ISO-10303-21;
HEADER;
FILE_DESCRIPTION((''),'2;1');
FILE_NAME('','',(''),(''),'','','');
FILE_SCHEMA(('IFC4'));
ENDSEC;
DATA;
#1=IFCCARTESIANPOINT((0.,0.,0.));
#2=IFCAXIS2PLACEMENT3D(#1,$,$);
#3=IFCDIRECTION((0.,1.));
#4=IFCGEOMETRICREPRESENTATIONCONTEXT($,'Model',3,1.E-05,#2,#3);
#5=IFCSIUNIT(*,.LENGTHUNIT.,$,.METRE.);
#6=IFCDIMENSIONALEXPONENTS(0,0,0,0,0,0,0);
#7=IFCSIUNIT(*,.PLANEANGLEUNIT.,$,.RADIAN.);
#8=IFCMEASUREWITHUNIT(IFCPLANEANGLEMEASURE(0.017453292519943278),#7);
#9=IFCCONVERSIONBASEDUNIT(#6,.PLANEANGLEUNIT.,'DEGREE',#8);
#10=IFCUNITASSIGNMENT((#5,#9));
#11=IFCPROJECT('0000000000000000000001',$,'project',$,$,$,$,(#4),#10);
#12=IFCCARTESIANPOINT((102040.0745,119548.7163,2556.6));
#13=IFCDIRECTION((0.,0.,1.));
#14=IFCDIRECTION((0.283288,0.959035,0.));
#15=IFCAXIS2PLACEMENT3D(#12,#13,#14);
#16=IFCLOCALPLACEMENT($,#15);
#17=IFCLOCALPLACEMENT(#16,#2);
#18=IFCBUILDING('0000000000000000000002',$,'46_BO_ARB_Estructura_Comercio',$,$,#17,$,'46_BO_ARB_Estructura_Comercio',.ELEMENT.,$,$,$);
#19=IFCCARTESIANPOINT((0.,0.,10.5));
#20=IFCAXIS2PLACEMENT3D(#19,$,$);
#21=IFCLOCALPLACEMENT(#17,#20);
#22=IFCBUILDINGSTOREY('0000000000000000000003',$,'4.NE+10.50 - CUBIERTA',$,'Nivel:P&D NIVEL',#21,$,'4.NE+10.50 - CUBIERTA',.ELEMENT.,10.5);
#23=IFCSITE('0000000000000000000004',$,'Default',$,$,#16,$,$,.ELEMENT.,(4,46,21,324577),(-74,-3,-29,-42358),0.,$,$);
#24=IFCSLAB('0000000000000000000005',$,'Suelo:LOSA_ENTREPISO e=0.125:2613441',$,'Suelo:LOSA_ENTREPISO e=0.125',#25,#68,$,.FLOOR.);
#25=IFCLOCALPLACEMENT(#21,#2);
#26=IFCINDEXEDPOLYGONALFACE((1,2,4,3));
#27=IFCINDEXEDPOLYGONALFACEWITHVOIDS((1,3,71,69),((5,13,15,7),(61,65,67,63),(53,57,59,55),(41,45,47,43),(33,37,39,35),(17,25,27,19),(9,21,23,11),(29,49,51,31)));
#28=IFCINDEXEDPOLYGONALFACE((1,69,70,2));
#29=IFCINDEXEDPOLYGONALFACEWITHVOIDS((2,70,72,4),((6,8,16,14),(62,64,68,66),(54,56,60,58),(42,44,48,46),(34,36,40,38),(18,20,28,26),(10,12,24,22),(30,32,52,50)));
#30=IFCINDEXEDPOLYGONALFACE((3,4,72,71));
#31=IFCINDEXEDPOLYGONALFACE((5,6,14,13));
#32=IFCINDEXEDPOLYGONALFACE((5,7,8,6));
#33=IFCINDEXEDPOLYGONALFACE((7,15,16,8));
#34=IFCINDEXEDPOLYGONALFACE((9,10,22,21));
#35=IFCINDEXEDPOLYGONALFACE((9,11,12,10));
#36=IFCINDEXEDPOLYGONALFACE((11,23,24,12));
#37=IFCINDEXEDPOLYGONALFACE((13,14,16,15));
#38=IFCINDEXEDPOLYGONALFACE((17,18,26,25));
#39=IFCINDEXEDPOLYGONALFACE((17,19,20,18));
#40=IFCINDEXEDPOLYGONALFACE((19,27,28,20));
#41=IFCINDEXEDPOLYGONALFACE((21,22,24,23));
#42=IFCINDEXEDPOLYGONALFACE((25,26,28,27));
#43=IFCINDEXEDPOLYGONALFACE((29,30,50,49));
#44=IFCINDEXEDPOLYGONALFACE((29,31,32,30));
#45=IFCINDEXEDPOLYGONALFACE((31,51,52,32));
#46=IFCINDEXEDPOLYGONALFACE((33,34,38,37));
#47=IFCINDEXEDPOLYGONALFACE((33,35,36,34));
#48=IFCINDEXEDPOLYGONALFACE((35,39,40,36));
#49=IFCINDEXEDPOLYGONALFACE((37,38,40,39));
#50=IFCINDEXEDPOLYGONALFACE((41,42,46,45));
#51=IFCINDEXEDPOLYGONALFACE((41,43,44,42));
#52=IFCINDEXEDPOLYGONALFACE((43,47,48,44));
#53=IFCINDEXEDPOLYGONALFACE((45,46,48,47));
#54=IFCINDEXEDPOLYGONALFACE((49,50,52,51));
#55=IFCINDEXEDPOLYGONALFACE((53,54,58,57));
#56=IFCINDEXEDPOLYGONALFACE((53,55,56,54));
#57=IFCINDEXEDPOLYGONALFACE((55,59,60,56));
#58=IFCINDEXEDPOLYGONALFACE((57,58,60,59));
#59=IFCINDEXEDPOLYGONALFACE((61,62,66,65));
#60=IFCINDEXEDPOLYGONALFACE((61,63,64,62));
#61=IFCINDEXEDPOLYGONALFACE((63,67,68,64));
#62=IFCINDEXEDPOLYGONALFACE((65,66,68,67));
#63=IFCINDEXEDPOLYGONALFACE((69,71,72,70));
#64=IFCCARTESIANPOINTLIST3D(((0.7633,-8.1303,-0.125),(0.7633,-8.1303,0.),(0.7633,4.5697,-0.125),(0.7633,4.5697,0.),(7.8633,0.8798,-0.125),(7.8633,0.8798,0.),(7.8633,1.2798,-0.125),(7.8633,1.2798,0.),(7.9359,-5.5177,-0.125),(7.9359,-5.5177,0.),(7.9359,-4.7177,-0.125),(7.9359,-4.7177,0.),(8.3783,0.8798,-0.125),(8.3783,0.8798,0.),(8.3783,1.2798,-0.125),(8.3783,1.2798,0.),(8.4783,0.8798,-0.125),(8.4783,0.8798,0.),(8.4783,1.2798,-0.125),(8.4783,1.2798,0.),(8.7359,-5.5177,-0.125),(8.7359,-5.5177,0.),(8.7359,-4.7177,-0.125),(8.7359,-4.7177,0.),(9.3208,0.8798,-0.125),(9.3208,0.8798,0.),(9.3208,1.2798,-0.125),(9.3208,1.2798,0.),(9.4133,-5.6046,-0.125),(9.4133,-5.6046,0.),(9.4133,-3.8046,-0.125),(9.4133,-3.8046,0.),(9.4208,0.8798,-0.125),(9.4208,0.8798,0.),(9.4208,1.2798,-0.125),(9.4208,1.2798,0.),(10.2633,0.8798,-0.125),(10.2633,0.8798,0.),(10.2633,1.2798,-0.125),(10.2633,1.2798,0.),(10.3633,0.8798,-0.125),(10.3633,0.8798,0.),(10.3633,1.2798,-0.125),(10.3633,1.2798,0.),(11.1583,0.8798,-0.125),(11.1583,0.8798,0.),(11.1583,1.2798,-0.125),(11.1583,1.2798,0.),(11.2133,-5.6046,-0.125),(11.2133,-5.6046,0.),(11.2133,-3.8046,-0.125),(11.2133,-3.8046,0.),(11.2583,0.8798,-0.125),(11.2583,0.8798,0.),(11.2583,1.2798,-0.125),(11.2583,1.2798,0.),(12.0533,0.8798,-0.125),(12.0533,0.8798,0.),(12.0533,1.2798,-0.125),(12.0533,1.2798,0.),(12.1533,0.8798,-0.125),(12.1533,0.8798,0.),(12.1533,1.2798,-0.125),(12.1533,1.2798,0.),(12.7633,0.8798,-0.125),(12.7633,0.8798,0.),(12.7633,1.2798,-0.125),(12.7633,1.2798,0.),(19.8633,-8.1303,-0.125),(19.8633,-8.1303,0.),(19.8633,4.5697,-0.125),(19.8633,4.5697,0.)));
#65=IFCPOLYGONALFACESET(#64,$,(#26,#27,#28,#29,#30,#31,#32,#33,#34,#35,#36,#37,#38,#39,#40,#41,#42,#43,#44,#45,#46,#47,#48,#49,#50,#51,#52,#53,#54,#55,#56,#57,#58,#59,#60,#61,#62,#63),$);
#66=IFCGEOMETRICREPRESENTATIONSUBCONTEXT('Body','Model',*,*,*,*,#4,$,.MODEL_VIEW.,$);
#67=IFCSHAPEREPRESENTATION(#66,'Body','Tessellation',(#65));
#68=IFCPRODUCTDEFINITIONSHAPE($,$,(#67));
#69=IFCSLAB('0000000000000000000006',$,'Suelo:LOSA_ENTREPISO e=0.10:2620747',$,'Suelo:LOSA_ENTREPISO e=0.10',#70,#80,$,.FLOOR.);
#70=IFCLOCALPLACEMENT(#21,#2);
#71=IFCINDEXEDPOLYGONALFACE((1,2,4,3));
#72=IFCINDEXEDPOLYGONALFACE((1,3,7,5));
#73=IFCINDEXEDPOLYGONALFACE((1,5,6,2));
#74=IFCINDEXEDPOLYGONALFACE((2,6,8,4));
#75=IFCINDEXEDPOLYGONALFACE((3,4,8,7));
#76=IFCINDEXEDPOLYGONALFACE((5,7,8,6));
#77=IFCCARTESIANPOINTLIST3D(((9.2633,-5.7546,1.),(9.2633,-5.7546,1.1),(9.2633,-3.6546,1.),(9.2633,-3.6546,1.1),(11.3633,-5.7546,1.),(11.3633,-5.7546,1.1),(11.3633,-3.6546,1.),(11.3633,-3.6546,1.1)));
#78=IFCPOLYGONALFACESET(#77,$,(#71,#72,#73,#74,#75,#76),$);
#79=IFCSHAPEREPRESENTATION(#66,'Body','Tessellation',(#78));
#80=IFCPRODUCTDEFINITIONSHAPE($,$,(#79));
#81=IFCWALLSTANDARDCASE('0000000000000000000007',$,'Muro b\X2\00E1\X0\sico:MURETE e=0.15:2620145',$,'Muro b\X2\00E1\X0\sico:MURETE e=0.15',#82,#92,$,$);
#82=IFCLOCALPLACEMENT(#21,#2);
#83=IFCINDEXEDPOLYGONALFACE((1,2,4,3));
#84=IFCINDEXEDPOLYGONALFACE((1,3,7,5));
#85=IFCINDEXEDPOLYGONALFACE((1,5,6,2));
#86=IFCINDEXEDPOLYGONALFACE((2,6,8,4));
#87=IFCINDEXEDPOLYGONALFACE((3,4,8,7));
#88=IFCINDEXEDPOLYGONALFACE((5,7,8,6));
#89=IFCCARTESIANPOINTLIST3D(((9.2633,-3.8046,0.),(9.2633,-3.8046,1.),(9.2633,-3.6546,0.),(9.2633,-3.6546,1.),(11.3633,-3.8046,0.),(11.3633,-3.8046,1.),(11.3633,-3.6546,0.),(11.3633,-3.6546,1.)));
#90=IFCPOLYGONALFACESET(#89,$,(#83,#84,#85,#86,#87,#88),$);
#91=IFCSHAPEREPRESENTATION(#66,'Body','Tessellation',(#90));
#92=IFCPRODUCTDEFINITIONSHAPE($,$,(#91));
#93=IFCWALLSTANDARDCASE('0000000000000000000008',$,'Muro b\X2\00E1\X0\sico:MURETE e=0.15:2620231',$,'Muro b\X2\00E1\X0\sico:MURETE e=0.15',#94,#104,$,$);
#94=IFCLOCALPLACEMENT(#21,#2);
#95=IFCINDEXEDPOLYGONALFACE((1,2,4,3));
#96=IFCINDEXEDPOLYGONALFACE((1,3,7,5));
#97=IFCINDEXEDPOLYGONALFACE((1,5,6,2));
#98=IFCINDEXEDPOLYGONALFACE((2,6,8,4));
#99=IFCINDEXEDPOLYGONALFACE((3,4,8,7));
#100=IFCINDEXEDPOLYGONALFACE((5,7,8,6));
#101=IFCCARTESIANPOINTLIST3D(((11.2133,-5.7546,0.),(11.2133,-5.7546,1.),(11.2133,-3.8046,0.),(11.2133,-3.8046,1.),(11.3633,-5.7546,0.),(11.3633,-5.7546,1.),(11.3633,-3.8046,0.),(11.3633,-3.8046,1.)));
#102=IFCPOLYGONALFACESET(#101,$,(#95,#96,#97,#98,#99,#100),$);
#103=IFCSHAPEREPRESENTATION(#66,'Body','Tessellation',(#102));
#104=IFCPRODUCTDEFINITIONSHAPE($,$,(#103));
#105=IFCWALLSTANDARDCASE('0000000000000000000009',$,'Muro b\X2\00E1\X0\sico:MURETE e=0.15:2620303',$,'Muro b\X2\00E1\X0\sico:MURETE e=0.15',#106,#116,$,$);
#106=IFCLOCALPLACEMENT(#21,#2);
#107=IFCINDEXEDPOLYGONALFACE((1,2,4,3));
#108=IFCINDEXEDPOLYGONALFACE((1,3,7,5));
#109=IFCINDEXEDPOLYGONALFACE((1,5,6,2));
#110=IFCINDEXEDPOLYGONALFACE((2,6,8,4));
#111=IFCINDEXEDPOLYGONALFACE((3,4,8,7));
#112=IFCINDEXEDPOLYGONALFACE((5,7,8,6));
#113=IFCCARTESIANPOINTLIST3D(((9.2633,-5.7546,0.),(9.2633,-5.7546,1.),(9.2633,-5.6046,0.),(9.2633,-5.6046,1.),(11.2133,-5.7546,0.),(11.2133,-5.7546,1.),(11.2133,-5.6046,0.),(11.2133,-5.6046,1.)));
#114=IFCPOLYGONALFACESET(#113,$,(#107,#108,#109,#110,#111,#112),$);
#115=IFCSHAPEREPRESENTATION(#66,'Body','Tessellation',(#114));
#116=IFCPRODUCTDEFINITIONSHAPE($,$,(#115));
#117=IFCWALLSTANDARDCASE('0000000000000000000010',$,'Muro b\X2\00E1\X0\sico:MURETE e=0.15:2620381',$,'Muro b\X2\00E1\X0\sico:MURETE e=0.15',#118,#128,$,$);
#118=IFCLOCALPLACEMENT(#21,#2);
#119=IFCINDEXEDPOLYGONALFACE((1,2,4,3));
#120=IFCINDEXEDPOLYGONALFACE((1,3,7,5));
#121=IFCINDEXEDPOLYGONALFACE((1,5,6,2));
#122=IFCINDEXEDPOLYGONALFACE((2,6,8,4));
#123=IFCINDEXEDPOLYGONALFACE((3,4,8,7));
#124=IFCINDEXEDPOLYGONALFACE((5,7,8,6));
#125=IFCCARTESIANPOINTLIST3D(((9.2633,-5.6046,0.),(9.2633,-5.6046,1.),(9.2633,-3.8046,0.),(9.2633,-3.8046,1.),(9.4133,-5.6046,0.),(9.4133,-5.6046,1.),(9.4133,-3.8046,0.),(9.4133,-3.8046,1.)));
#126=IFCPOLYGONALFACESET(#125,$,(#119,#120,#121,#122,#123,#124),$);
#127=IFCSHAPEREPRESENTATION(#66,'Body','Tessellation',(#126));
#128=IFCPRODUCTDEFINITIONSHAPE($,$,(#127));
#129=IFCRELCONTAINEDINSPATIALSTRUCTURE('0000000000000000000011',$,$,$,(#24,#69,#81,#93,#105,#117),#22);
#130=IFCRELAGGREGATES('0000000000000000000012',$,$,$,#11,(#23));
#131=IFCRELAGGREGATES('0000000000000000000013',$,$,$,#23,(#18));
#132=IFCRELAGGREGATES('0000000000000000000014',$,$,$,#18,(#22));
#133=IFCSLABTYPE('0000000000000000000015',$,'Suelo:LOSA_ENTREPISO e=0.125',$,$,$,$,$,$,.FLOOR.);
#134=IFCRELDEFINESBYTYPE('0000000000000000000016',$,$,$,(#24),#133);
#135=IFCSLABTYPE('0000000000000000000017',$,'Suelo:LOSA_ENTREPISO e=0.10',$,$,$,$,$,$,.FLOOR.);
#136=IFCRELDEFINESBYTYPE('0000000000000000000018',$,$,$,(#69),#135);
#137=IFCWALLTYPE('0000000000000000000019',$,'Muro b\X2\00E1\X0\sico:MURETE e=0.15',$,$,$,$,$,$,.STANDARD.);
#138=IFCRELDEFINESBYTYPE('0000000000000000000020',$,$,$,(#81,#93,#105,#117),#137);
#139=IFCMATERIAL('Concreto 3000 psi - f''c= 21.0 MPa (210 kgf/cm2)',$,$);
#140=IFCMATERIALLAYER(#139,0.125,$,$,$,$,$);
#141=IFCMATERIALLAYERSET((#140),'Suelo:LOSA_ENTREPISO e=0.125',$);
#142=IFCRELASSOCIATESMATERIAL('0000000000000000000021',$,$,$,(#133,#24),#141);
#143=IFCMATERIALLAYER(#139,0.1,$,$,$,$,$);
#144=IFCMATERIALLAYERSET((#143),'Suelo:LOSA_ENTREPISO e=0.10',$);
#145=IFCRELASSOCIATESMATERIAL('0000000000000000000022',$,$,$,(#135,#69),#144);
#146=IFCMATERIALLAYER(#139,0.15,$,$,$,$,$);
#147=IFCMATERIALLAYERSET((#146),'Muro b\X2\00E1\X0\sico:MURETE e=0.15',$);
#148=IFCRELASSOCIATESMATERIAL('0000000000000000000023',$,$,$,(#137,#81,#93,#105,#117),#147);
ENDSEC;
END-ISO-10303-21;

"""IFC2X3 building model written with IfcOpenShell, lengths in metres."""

from ifc_helpers import new_model, entity, si_unit, converted_unit, direction, frame, frame_2d, origin, origin_2d_with_axis, place, context, subcontext, project, spatial, rectangle, extrude, boolean, material, layer, layer_set, layer_usage, type_object, element, save


model = new_model("IFC2X3")

# Units and contexts
model_context = context("Model", 3, precision=1e-05, world=origin(), true_north=direction((0.0, 1.0)))
body_context = subcontext(model_context, "Body", "Model", "MODEL_VIEW")
ifc_project = project(units=[si_unit("LENGTHUNIT", "METRE"), converted_unit("PLANEANGLEUNIT", "DEGREE", entity("IfcPlaneAngleMeasure", 0.017453292519943278), si_unit("PLANEANGLEUNIT", "RADIAN"), dimensions=[0, 0, 0, 0, 0, 0, 0])], contexts=[model_context])

# Site, building, storey
site_placement = place(None, frame((102040.0745, 119548.7163, 2556.6), z_axis=(0.0, 0.0, 1.0), x_axis=(0.283288, 0.959035, 0.0)))
site = spatial("IfcSite", under=ifc_project, at=site_placement, Name="Default", CompositionType="ELEMENT", RefLatitude=(4, 46, 21, 324577), RefLongitude=(-74, -3, -29, -42358), RefElevation=0.0)
building_placement = place(site_placement, origin())
building = spatial("IfcBuilding", under=site, at=building_placement, Name="46_BO_ARB_Estructura_Comercio", LongName="46_BO_ARB_Estructura_Comercio", CompositionType="ELEMENT")
storey_placement = place(building_placement, frame((0.0, 0.0, 10.5)))
storey = spatial("IfcBuildingStorey", under=building, at=storey_placement, Name="4.NE+10.50 - CUBIERTA", ObjectType="Nivel:P&D NIVEL", LongName="4.NE+10.50 - CUBIERTA", CompositionType="ELEMENT", Elevation=10.5)

# Shared definitions
ifc_material = material(Name="Concreto 3000 psi - f'c= 21.0 MPa (210 kgf/cm2)")

# Slab, openings
ifc_layer_1 = layer(ifc_material, 0.125)
ifc_layer_set_1 = layer_set([ifc_layer_1], Name="Suelo:LOSA_ENTREPISO e=0.125")
ifc_layer_usage_1 = layer_usage(ifc_layer_set_1, "AXIS3", "POSITIVE", 0.0)
slab_type_1 = type_object("IfcSlabType", Name="Suelo:LOSA_ENTREPISO e=0.125", PredefinedType="FLOOR", material=ifc_layer_set_1)
slab_1_placement = place(storey_placement, origin())
slab_1 = element("IfcSlab", 1, at=slab_1_placement, inside=storey, type_object=slab_type_1, material=ifc_layer_usage_1, Name="Suelo:LOSA_ENTREPISO e=0.125:2613441", ObjectType="Suelo:LOSA_ENTREPISO e=0.125", PredefinedType="FLOOR", context=body_context, shape_type="SweptSolid", body=[
    boolean("DIFFERENCE", boolean("DIFFERENCE", boolean("DIFFERENCE", boolean("DIFFERENCE", boolean("DIFFERENCE", boolean("DIFFERENCE", boolean("DIFFERENCE", boolean("DIFFERENCE", extrude(rectangle(XDim=12.7, YDim=19.1, at=origin_2d_with_axis()), frame((10.3133, -1.7803, 0.0), z_axis=(0.0, 0.0, -1.0), x_axis=(0.0, 1.0, 0.0)), (0.0, 0.0, 1.0), 0.125), extrude(rectangle(XDim=0.4, YDim=0.515, at=origin_2d_with_axis()), frame((8.1208, 1.0798, -0.125), z_axis=(0.0, 0.0, 1.0), x_axis=(0.0, 1.0, 0.0)), (0.0, 0.0, 1.0), 0.125)), extrude(rectangle(XDim=0.8, YDim=0.8, at=origin_2d_with_axis()), frame((8.3359, -5.1177, -0.125), z_axis=(0.0, 0.0, 1.0), x_axis=(0.0, 1.0, 0.0)), (0.0, 0.0, 1.0), 0.125)), extrude(rectangle(XDim=0.4, YDim=0.8425, at=origin_2d_with_axis()), frame((8.8995, 1.0798, -0.125), z_axis=(0.0, 0.0, 1.0), x_axis=(0.0, 1.0, 0.0)), (0.0, 0.0, 1.0), 0.125)), extrude(rectangle(XDim=0.4, YDim=0.8425, at=origin_2d_with_axis()), frame((9.842, 1.0798, -0.125), z_axis=(0.0, 0.0, 1.0), x_axis=(0.0, 1.0, 0.0)), (0.0, 0.0, 1.0), 0.125)), extrude(rectangle(XDim=0.4, YDim=0.795, at=frame_2d((0.0, 0.0), x_axis=(1.0, 0.0))), frame((10.7608, 1.0798, -0.125), z_axis=(0.0, 0.0, 1.0), x_axis=(0.0, 1.0, 0.0)), (0.0, 0.0, 1.0), 0.125)), extrude(rectangle(XDim=1.8, YDim=1.8, at=origin_2d_with_axis()), frame((10.3133, -4.7046, -0.125), z_axis=(0.0, 0.0, 1.0), x_axis=(0.0, 1.0, 0.0)), (0.0, 0.0, 1.0), 0.125)), extrude(rectangle(XDim=0.4, YDim=0.795, at=frame_2d((0.0, 0.0), x_axis=(1.0, 0.0))), frame((11.6558, 1.0798, -0.125), z_axis=(0.0, 0.0, 1.0), x_axis=(0.0, 1.0, 0.0)), (0.0, 0.0, 1.0), 0.125)), extrude(rectangle(XDim=0.4, YDim=0.61, at=frame_2d((0.0, 0.0), x_axis=(1.0, 0.0))), frame((12.4583, 1.0798, -0.125), z_axis=(0.0, 0.0, 1.0), x_axis=(0.0, 1.0, 0.0)), (0.0, 0.0, 1.0), 0.125)),
])
opening_1_placement = place(slab_1_placement, origin())
element("IfcOpeningElement", 2, at=opening_1_placement, cuts=slab_1, ObjectType="Opening", context=body_context, shape_type="SweptSolid", body=[
    extrude(rectangle(XDim=0.515, YDim=0.4, at=origin_2d_with_axis()), frame((8.1208, 1.0798, 0.0), z_axis=(0.0, 0.0, -1.0), x_axis=(-1.0, 0.0, 0.0)), (0.0, 0.0, 1.0), 0.125),
])
opening_2_placement = place(slab_1_placement, origin())
element("IfcOpeningElement", 3, at=opening_2_placement, cuts=slab_1, ObjectType="Opening", context=body_context, shape_type="SweptSolid", body=[
    extrude(rectangle(XDim=0.4, YDim=0.8425, at=frame_2d((0.0, 0.0), x_axis=(1.0, 0.0))), frame((8.8995, 1.0798, 0.0), z_axis=(0.0, 0.0, -1.0), x_axis=(0.0, -1.0, 0.0)), (0.0, 0.0, 1.0), 0.125),
])
opening_3_placement = place(slab_1_placement, origin())
element("IfcOpeningElement", 4, at=opening_3_placement, cuts=slab_1, ObjectType="Opening", context=body_context, shape_type="SweptSolid", body=[
    extrude(rectangle(XDim=0.4, YDim=0.8425, at=origin_2d_with_axis()), frame((9.842, 1.0798, 0.0), z_axis=(0.0, 0.0, -1.0), x_axis=(0.0, -1.0, 0.0)), (0.0, 0.0, 1.0), 0.125),
])
opening_4_placement = place(slab_1_placement, origin())
element("IfcOpeningElement", 5, at=opening_4_placement, cuts=slab_1, ObjectType="Opening", context=body_context, shape_type="SweptSolid", body=[
    extrude(rectangle(XDim=0.4, YDim=0.795, at=frame_2d((0.0, 0.0), x_axis=(1.0, 0.0))), frame((10.7608, 1.0798, 0.0), z_axis=(0.0, 0.0, -1.0), x_axis=(0.0, -1.0, 0.0)), (0.0, 0.0, 1.0), 0.125),
])
opening_5_placement = place(slab_1_placement, origin())
element("IfcOpeningElement", 6, at=opening_5_placement, cuts=slab_1, ObjectType="Opening", context=body_context, shape_type="SweptSolid", body=[
    extrude(rectangle(XDim=0.4, YDim=0.795, at=frame_2d((0.0, 0.0), x_axis=(1.0, 0.0))), frame((11.6558, 1.0798, 0.0), z_axis=(0.0, 0.0, -1.0), x_axis=(0.0, -1.0, 0.0)), (0.0, 0.0, 1.0), 0.125),
])
opening_6_placement = place(slab_1_placement, origin())
element("IfcOpeningElement", 7, at=opening_6_placement, cuts=slab_1, ObjectType="Opening", context=body_context, shape_type="SweptSolid", body=[
    extrude(rectangle(XDim=0.4, YDim=0.61, at=frame_2d((0.0, 0.0), x_axis=(1.0, 0.0))), frame((12.4583, 1.0798, 0.0), z_axis=(0.0, 0.0, -1.0), x_axis=(0.0, -1.0, 0.0)), (0.0, 0.0, 1.0), 0.125),
])
opening_7_placement = place(slab_1_placement, origin())
element("IfcOpeningElement", 8, at=opening_7_placement, cuts=slab_1, ObjectType="Opening", context=body_context, shape_type="SweptSolid", body=[
    extrude(rectangle(XDim=1.8, YDim=1.8, at=frame_2d((0.0, 0.0), x_axis=(1.0, 0.0))), frame((10.3133, -4.7046, 0.0), z_axis=(0.0, 0.0, -1.0), x_axis=(0.0, -1.0, 0.0)), (0.0, 0.0, 1.0), 0.125),
])
opening_8_placement = place(slab_1_placement, origin())
element("IfcOpeningElement", 9, at=opening_8_placement, cuts=slab_1, ObjectType="Opening", context=body_context, shape_type="SweptSolid", body=[
    extrude(rectangle(XDim=0.8, YDim=0.8, at=origin_2d_with_axis()), frame((8.3359, -5.1177, 0.0), z_axis=(0.0, 0.0, -1.0), x_axis=(0.0, -1.0, 0.0)), (0.0, 0.0, 1.0), 0.125),
])

# Slab
ifc_layer_2 = layer(ifc_material, 0.1)
ifc_layer_set_2 = layer_set([ifc_layer_2], Name="Suelo:LOSA_ENTREPISO e=0.10")
ifc_layer_usage_2 = layer_usage(ifc_layer_set_2, "AXIS3", "POSITIVE", 0.0)
slab_type_2 = type_object("IfcSlabType", Name="Suelo:LOSA_ENTREPISO e=0.10", PredefinedType="FLOOR", material=ifc_layer_set_2)
slab_2_placement = place(storey_placement, origin())
element("IfcSlab", 10, at=slab_2_placement, inside=storey, type_object=slab_type_2, material=ifc_layer_usage_2, Name="Suelo:LOSA_ENTREPISO e=0.10:2620747", ObjectType="Suelo:LOSA_ENTREPISO e=0.10", PredefinedType="FLOOR", context=body_context, shape_type="SweptSolid", body=[
    extrude(rectangle(XDim=2.1, YDim=2.1, at=frame_2d((0.0, 0.0), x_axis=(1.0, 0.0))), frame((10.3133, -4.7046, 1.1), z_axis=(0.0, 0.0, -1.0), x_axis=(0.0, 1.0, 0.0)), (0.0, 0.0, 1.0), 0.1),
])

# Walls
ifc_layer_3 = layer(ifc_material, 0.15)
ifc_layer_set_3 = layer_set([ifc_layer_3], Name="Muro básico:MURETE e=0.15")
ifc_layer_usage_3 = layer_usage(ifc_layer_set_3, "AXIS2", "NEGATIVE", 0.075)
wall_type = type_object("IfcWallType", Name="Muro básico:MURETE e=0.15", PredefinedType="STANDARD", material=ifc_layer_set_3)
wall_1_placement = place(storey_placement, frame((9.2633, -3.7296, 0.0)))
element("IfcWallStandardCase", 11, at=wall_1_placement, inside=storey, type_object=wall_type, material=ifc_layer_usage_3, Name="Muro básico:MURETE e=0.15:2620145", ObjectType="Muro básico:MURETE e=0.15", context=body_context, shape_type="SweptSolid", body=[
    extrude(rectangle(XDim=2.1, YDim=0.15, at=frame_2d((1.05, 0.0), x_axis=(-1.0, 0.0))), origin(), (0.0, 0.0, 1.0), 1.0),
])
ifc_layer_usage_4 = layer_usage(ifc_layer_set_3, "AXIS2", "NEGATIVE", 0.075)
wall_2_placement = place(storey_placement, frame((11.2883, -3.8046, 0.0), z_axis=(0.0, 0.0, 1.0), x_axis=(0.0, -1.0, 0.0)))
element("IfcWallStandardCase", 12, at=wall_2_placement, inside=storey, type_object=wall_type, material=ifc_layer_usage_4, Name="Muro básico:MURETE e=0.15:2620231", ObjectType="Muro básico:MURETE e=0.15", context=body_context, shape_type="SweptSolid", body=[
    extrude(rectangle(XDim=1.95, YDim=0.15, at=frame_2d((0.975, 0.0), x_axis=(-1.0, 0.0))), origin(), (0.0, 0.0, 1.0), 1.0),
])
ifc_layer_usage_5 = layer_usage(ifc_layer_set_3, "AXIS2", "NEGATIVE", 0.075)
wall_3_placement = place(storey_placement, frame((11.2133, -5.6796, 0.0), z_axis=(0.0, 0.0, 1.0), x_axis=(-1.0, 0.0, 0.0)))
element("IfcWallStandardCase", 13, at=wall_3_placement, inside=storey, type_object=wall_type, material=ifc_layer_usage_5, Name="Muro básico:MURETE e=0.15:2620303", ObjectType="Muro básico:MURETE e=0.15", context=body_context, shape_type="SweptSolid", body=[
    extrude(rectangle(XDim=1.95, YDim=0.15, at=frame_2d((0.975, 0.0), x_axis=(-1.0, 0.0))), origin(), (0.0, 0.0, 1.0), 1.0),
])
ifc_layer_usage_6 = layer_usage(ifc_layer_set_3, "AXIS2", "NEGATIVE", 0.075)
wall_4_placement = place(storey_placement, frame((9.3383, -5.6046, 0.0), z_axis=(0.0, 0.0, 1.0), x_axis=(0.0, 1.0, 0.0)))
element("IfcWallStandardCase", 14, at=wall_4_placement, inside=storey, type_object=wall_type, material=ifc_layer_usage_6, Name="Muro básico:MURETE e=0.15:2620381", ObjectType="Muro básico:MURETE e=0.15", context=body_context, shape_type="SweptSolid", body=[
    extrude(rectangle(XDim=1.8, YDim=0.15, at=frame_2d((0.9, 0.0), x_axis=(-1.0, 0.0))), origin(), (0.0, 0.0, 1.0), 1.0),
])

save(model, "model.ifc")
